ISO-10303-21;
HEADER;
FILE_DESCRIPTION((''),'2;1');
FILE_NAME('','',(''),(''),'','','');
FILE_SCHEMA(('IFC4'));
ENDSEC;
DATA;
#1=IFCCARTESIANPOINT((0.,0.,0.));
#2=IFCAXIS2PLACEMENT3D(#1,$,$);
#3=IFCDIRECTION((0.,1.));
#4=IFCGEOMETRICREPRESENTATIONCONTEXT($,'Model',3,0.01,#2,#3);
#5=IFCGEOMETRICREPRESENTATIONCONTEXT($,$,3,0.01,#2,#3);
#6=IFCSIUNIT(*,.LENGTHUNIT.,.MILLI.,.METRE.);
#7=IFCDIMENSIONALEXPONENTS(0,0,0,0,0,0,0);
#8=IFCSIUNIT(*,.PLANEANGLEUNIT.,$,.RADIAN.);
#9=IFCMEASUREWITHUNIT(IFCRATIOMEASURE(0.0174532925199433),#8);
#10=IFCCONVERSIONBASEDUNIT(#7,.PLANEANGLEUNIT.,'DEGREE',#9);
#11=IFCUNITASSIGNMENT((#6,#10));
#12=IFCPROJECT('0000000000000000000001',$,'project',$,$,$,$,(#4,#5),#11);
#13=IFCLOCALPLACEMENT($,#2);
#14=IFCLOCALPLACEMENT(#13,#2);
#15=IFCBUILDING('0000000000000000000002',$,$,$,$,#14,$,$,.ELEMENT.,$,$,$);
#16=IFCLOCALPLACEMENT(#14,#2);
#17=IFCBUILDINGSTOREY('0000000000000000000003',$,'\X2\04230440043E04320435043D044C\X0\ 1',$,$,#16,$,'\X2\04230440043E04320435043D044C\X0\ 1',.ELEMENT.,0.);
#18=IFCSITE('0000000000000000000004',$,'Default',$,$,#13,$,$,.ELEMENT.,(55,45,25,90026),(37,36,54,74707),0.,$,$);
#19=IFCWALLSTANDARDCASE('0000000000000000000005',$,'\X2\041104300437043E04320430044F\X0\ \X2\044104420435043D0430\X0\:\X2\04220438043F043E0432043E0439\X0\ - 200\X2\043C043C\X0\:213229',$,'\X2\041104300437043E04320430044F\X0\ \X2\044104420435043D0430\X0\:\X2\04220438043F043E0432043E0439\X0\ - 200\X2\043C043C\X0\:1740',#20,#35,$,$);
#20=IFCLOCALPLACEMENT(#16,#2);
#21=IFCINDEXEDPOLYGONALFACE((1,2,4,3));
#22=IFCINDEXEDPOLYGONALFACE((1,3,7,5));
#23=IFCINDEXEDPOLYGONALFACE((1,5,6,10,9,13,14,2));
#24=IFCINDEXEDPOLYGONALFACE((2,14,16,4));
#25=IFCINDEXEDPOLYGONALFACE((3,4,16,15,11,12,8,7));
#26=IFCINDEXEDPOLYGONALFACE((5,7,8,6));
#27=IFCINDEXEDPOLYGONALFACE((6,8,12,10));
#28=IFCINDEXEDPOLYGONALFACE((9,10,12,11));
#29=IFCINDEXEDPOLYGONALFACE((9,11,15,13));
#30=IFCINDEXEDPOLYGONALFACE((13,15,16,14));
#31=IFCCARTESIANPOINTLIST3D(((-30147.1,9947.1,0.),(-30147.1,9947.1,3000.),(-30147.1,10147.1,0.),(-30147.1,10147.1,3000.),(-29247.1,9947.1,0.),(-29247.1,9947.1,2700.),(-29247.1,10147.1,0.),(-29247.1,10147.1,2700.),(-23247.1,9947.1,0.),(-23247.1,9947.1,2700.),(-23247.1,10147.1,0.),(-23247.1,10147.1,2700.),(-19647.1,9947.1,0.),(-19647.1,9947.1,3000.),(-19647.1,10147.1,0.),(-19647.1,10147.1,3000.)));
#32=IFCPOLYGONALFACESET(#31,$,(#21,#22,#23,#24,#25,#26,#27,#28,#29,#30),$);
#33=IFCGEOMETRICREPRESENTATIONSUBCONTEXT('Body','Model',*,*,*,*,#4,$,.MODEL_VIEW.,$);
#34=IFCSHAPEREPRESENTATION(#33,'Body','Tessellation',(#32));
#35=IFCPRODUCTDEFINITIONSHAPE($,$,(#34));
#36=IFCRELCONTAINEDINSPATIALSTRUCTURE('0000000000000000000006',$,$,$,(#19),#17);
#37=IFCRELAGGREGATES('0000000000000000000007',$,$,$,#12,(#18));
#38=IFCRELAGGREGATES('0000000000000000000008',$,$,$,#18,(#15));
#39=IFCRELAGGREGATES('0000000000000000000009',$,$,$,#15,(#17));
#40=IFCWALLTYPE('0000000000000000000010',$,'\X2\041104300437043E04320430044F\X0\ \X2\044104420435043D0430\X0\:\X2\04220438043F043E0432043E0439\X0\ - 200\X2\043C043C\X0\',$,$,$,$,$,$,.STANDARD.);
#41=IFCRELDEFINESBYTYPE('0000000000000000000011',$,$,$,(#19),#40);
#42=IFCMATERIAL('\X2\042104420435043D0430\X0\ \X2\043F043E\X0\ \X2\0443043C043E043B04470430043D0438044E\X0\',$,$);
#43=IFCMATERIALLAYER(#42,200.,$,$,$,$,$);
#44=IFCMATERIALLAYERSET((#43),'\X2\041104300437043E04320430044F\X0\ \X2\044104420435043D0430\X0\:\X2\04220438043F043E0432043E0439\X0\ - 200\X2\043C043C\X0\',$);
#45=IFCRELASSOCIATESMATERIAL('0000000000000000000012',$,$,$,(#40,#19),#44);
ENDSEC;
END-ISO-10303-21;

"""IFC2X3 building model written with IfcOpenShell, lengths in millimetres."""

from ifc_helpers import new_model, entity, si_unit, converted_unit, direction, frame, frame_2d, origin, place, context, subcontext, project, spatial, rectangle, extrude, material, layer, layer_set, layer_usage, type_object, element, save


model = new_model("IFC2X3")

# Units and contexts
model_context = context("Model", 3, precision=0.01, world=origin(), true_north=direction((0.0, 1.0)))
context_of_model = context(None, 3, precision=0.01, world=origin(), true_north=direction((0.0, 1.0)))
body_context = subcontext(model_context, "Body", "Model", "MODEL_VIEW")
ifc_project = project(units=[si_unit("LENGTHUNIT", "METRE", prefix="MILLI"), converted_unit("PLANEANGLEUNIT", "DEGREE", entity("IfcRatioMeasure", 0.0174532925199433), si_unit("PLANEANGLEUNIT", "RADIAN"), dimensions=[0, 0, 0, 0, 0, 0, 0])], contexts=[model_context, context_of_model])

# Site, building, storey
site_placement = place(None, origin())
site = spatial("IfcSite", under=ifc_project, at=site_placement, Name="Default", CompositionType="ELEMENT", RefLatitude=(55, 45, 25, 90026), RefLongitude=(37, 36, 54, 74707), RefElevation=0.0)
building_placement = place(site_placement, origin())
building = spatial("IfcBuilding", under=site, at=building_placement, CompositionType="ELEMENT")
storey_placement = place(building_placement, origin())
storey = spatial("IfcBuildingStorey", under=building, at=storey_placement, Name="Уровень 1", LongName="Уровень 1", CompositionType="ELEMENT", Elevation=0.0)

# Wall, opening
ifc_material = material(Name="Стена по умолчанию")
ifc_layer = layer(ifc_material, 200.0)
ifc_layer_set = layer_set([ifc_layer], Name="Базовая стена:Типовой - 200мм")
ifc_layer_usage = layer_usage(ifc_layer_set, "AXIS2", "NEGATIVE", 100.0)
wall_type = type_object("IfcWallType", Name="Базовая стена:Типовой - 200мм", PredefinedType="STANDARD", material=ifc_layer_set)
wall_placement = place(storey_placement, frame((-30147.1, 10047.1, 0.0)))
wall = element("IfcWallStandardCase", 1, at=wall_placement, inside=storey, type_object=wall_type, material=ifc_layer_usage, Name="Базовая стена:Типовой - 200мм:213229", ObjectType="Базовая стена:Типовой - 200мм:1740", context=body_context, shape_type="SweptSolid", body=[
    extrude(rectangle(XDim=10500.0, YDim=200.0, at=frame_2d((5250.0, 0.0), x_axis=(-1.0, 0.0))), origin(), (0.0, 0.0, 1.0), 3000.0),
])
opening_placement = place(wall_placement, frame((30147.1, -10047.1, -300.0)))
element("IfcOpeningElement", 2, at=opening_placement, cuts=wall, ObjectType="Opening", context=body_context, shape_type="SweptSolid", body=[
    extrude(rectangle(XDim=3000.0, YDim=6000.0, at=frame_2d((0.0, 0.0), x_axis=(1.0, 0.0))), frame((-26247.1, 9607.1, 1500.0), z_axis=(0.0, 1.0, 0.0), x_axis=(0.0, 0.0, -1.0)), (0.0, 0.0, 1.0), 540.0),
])

save(model, "model.ifc")
